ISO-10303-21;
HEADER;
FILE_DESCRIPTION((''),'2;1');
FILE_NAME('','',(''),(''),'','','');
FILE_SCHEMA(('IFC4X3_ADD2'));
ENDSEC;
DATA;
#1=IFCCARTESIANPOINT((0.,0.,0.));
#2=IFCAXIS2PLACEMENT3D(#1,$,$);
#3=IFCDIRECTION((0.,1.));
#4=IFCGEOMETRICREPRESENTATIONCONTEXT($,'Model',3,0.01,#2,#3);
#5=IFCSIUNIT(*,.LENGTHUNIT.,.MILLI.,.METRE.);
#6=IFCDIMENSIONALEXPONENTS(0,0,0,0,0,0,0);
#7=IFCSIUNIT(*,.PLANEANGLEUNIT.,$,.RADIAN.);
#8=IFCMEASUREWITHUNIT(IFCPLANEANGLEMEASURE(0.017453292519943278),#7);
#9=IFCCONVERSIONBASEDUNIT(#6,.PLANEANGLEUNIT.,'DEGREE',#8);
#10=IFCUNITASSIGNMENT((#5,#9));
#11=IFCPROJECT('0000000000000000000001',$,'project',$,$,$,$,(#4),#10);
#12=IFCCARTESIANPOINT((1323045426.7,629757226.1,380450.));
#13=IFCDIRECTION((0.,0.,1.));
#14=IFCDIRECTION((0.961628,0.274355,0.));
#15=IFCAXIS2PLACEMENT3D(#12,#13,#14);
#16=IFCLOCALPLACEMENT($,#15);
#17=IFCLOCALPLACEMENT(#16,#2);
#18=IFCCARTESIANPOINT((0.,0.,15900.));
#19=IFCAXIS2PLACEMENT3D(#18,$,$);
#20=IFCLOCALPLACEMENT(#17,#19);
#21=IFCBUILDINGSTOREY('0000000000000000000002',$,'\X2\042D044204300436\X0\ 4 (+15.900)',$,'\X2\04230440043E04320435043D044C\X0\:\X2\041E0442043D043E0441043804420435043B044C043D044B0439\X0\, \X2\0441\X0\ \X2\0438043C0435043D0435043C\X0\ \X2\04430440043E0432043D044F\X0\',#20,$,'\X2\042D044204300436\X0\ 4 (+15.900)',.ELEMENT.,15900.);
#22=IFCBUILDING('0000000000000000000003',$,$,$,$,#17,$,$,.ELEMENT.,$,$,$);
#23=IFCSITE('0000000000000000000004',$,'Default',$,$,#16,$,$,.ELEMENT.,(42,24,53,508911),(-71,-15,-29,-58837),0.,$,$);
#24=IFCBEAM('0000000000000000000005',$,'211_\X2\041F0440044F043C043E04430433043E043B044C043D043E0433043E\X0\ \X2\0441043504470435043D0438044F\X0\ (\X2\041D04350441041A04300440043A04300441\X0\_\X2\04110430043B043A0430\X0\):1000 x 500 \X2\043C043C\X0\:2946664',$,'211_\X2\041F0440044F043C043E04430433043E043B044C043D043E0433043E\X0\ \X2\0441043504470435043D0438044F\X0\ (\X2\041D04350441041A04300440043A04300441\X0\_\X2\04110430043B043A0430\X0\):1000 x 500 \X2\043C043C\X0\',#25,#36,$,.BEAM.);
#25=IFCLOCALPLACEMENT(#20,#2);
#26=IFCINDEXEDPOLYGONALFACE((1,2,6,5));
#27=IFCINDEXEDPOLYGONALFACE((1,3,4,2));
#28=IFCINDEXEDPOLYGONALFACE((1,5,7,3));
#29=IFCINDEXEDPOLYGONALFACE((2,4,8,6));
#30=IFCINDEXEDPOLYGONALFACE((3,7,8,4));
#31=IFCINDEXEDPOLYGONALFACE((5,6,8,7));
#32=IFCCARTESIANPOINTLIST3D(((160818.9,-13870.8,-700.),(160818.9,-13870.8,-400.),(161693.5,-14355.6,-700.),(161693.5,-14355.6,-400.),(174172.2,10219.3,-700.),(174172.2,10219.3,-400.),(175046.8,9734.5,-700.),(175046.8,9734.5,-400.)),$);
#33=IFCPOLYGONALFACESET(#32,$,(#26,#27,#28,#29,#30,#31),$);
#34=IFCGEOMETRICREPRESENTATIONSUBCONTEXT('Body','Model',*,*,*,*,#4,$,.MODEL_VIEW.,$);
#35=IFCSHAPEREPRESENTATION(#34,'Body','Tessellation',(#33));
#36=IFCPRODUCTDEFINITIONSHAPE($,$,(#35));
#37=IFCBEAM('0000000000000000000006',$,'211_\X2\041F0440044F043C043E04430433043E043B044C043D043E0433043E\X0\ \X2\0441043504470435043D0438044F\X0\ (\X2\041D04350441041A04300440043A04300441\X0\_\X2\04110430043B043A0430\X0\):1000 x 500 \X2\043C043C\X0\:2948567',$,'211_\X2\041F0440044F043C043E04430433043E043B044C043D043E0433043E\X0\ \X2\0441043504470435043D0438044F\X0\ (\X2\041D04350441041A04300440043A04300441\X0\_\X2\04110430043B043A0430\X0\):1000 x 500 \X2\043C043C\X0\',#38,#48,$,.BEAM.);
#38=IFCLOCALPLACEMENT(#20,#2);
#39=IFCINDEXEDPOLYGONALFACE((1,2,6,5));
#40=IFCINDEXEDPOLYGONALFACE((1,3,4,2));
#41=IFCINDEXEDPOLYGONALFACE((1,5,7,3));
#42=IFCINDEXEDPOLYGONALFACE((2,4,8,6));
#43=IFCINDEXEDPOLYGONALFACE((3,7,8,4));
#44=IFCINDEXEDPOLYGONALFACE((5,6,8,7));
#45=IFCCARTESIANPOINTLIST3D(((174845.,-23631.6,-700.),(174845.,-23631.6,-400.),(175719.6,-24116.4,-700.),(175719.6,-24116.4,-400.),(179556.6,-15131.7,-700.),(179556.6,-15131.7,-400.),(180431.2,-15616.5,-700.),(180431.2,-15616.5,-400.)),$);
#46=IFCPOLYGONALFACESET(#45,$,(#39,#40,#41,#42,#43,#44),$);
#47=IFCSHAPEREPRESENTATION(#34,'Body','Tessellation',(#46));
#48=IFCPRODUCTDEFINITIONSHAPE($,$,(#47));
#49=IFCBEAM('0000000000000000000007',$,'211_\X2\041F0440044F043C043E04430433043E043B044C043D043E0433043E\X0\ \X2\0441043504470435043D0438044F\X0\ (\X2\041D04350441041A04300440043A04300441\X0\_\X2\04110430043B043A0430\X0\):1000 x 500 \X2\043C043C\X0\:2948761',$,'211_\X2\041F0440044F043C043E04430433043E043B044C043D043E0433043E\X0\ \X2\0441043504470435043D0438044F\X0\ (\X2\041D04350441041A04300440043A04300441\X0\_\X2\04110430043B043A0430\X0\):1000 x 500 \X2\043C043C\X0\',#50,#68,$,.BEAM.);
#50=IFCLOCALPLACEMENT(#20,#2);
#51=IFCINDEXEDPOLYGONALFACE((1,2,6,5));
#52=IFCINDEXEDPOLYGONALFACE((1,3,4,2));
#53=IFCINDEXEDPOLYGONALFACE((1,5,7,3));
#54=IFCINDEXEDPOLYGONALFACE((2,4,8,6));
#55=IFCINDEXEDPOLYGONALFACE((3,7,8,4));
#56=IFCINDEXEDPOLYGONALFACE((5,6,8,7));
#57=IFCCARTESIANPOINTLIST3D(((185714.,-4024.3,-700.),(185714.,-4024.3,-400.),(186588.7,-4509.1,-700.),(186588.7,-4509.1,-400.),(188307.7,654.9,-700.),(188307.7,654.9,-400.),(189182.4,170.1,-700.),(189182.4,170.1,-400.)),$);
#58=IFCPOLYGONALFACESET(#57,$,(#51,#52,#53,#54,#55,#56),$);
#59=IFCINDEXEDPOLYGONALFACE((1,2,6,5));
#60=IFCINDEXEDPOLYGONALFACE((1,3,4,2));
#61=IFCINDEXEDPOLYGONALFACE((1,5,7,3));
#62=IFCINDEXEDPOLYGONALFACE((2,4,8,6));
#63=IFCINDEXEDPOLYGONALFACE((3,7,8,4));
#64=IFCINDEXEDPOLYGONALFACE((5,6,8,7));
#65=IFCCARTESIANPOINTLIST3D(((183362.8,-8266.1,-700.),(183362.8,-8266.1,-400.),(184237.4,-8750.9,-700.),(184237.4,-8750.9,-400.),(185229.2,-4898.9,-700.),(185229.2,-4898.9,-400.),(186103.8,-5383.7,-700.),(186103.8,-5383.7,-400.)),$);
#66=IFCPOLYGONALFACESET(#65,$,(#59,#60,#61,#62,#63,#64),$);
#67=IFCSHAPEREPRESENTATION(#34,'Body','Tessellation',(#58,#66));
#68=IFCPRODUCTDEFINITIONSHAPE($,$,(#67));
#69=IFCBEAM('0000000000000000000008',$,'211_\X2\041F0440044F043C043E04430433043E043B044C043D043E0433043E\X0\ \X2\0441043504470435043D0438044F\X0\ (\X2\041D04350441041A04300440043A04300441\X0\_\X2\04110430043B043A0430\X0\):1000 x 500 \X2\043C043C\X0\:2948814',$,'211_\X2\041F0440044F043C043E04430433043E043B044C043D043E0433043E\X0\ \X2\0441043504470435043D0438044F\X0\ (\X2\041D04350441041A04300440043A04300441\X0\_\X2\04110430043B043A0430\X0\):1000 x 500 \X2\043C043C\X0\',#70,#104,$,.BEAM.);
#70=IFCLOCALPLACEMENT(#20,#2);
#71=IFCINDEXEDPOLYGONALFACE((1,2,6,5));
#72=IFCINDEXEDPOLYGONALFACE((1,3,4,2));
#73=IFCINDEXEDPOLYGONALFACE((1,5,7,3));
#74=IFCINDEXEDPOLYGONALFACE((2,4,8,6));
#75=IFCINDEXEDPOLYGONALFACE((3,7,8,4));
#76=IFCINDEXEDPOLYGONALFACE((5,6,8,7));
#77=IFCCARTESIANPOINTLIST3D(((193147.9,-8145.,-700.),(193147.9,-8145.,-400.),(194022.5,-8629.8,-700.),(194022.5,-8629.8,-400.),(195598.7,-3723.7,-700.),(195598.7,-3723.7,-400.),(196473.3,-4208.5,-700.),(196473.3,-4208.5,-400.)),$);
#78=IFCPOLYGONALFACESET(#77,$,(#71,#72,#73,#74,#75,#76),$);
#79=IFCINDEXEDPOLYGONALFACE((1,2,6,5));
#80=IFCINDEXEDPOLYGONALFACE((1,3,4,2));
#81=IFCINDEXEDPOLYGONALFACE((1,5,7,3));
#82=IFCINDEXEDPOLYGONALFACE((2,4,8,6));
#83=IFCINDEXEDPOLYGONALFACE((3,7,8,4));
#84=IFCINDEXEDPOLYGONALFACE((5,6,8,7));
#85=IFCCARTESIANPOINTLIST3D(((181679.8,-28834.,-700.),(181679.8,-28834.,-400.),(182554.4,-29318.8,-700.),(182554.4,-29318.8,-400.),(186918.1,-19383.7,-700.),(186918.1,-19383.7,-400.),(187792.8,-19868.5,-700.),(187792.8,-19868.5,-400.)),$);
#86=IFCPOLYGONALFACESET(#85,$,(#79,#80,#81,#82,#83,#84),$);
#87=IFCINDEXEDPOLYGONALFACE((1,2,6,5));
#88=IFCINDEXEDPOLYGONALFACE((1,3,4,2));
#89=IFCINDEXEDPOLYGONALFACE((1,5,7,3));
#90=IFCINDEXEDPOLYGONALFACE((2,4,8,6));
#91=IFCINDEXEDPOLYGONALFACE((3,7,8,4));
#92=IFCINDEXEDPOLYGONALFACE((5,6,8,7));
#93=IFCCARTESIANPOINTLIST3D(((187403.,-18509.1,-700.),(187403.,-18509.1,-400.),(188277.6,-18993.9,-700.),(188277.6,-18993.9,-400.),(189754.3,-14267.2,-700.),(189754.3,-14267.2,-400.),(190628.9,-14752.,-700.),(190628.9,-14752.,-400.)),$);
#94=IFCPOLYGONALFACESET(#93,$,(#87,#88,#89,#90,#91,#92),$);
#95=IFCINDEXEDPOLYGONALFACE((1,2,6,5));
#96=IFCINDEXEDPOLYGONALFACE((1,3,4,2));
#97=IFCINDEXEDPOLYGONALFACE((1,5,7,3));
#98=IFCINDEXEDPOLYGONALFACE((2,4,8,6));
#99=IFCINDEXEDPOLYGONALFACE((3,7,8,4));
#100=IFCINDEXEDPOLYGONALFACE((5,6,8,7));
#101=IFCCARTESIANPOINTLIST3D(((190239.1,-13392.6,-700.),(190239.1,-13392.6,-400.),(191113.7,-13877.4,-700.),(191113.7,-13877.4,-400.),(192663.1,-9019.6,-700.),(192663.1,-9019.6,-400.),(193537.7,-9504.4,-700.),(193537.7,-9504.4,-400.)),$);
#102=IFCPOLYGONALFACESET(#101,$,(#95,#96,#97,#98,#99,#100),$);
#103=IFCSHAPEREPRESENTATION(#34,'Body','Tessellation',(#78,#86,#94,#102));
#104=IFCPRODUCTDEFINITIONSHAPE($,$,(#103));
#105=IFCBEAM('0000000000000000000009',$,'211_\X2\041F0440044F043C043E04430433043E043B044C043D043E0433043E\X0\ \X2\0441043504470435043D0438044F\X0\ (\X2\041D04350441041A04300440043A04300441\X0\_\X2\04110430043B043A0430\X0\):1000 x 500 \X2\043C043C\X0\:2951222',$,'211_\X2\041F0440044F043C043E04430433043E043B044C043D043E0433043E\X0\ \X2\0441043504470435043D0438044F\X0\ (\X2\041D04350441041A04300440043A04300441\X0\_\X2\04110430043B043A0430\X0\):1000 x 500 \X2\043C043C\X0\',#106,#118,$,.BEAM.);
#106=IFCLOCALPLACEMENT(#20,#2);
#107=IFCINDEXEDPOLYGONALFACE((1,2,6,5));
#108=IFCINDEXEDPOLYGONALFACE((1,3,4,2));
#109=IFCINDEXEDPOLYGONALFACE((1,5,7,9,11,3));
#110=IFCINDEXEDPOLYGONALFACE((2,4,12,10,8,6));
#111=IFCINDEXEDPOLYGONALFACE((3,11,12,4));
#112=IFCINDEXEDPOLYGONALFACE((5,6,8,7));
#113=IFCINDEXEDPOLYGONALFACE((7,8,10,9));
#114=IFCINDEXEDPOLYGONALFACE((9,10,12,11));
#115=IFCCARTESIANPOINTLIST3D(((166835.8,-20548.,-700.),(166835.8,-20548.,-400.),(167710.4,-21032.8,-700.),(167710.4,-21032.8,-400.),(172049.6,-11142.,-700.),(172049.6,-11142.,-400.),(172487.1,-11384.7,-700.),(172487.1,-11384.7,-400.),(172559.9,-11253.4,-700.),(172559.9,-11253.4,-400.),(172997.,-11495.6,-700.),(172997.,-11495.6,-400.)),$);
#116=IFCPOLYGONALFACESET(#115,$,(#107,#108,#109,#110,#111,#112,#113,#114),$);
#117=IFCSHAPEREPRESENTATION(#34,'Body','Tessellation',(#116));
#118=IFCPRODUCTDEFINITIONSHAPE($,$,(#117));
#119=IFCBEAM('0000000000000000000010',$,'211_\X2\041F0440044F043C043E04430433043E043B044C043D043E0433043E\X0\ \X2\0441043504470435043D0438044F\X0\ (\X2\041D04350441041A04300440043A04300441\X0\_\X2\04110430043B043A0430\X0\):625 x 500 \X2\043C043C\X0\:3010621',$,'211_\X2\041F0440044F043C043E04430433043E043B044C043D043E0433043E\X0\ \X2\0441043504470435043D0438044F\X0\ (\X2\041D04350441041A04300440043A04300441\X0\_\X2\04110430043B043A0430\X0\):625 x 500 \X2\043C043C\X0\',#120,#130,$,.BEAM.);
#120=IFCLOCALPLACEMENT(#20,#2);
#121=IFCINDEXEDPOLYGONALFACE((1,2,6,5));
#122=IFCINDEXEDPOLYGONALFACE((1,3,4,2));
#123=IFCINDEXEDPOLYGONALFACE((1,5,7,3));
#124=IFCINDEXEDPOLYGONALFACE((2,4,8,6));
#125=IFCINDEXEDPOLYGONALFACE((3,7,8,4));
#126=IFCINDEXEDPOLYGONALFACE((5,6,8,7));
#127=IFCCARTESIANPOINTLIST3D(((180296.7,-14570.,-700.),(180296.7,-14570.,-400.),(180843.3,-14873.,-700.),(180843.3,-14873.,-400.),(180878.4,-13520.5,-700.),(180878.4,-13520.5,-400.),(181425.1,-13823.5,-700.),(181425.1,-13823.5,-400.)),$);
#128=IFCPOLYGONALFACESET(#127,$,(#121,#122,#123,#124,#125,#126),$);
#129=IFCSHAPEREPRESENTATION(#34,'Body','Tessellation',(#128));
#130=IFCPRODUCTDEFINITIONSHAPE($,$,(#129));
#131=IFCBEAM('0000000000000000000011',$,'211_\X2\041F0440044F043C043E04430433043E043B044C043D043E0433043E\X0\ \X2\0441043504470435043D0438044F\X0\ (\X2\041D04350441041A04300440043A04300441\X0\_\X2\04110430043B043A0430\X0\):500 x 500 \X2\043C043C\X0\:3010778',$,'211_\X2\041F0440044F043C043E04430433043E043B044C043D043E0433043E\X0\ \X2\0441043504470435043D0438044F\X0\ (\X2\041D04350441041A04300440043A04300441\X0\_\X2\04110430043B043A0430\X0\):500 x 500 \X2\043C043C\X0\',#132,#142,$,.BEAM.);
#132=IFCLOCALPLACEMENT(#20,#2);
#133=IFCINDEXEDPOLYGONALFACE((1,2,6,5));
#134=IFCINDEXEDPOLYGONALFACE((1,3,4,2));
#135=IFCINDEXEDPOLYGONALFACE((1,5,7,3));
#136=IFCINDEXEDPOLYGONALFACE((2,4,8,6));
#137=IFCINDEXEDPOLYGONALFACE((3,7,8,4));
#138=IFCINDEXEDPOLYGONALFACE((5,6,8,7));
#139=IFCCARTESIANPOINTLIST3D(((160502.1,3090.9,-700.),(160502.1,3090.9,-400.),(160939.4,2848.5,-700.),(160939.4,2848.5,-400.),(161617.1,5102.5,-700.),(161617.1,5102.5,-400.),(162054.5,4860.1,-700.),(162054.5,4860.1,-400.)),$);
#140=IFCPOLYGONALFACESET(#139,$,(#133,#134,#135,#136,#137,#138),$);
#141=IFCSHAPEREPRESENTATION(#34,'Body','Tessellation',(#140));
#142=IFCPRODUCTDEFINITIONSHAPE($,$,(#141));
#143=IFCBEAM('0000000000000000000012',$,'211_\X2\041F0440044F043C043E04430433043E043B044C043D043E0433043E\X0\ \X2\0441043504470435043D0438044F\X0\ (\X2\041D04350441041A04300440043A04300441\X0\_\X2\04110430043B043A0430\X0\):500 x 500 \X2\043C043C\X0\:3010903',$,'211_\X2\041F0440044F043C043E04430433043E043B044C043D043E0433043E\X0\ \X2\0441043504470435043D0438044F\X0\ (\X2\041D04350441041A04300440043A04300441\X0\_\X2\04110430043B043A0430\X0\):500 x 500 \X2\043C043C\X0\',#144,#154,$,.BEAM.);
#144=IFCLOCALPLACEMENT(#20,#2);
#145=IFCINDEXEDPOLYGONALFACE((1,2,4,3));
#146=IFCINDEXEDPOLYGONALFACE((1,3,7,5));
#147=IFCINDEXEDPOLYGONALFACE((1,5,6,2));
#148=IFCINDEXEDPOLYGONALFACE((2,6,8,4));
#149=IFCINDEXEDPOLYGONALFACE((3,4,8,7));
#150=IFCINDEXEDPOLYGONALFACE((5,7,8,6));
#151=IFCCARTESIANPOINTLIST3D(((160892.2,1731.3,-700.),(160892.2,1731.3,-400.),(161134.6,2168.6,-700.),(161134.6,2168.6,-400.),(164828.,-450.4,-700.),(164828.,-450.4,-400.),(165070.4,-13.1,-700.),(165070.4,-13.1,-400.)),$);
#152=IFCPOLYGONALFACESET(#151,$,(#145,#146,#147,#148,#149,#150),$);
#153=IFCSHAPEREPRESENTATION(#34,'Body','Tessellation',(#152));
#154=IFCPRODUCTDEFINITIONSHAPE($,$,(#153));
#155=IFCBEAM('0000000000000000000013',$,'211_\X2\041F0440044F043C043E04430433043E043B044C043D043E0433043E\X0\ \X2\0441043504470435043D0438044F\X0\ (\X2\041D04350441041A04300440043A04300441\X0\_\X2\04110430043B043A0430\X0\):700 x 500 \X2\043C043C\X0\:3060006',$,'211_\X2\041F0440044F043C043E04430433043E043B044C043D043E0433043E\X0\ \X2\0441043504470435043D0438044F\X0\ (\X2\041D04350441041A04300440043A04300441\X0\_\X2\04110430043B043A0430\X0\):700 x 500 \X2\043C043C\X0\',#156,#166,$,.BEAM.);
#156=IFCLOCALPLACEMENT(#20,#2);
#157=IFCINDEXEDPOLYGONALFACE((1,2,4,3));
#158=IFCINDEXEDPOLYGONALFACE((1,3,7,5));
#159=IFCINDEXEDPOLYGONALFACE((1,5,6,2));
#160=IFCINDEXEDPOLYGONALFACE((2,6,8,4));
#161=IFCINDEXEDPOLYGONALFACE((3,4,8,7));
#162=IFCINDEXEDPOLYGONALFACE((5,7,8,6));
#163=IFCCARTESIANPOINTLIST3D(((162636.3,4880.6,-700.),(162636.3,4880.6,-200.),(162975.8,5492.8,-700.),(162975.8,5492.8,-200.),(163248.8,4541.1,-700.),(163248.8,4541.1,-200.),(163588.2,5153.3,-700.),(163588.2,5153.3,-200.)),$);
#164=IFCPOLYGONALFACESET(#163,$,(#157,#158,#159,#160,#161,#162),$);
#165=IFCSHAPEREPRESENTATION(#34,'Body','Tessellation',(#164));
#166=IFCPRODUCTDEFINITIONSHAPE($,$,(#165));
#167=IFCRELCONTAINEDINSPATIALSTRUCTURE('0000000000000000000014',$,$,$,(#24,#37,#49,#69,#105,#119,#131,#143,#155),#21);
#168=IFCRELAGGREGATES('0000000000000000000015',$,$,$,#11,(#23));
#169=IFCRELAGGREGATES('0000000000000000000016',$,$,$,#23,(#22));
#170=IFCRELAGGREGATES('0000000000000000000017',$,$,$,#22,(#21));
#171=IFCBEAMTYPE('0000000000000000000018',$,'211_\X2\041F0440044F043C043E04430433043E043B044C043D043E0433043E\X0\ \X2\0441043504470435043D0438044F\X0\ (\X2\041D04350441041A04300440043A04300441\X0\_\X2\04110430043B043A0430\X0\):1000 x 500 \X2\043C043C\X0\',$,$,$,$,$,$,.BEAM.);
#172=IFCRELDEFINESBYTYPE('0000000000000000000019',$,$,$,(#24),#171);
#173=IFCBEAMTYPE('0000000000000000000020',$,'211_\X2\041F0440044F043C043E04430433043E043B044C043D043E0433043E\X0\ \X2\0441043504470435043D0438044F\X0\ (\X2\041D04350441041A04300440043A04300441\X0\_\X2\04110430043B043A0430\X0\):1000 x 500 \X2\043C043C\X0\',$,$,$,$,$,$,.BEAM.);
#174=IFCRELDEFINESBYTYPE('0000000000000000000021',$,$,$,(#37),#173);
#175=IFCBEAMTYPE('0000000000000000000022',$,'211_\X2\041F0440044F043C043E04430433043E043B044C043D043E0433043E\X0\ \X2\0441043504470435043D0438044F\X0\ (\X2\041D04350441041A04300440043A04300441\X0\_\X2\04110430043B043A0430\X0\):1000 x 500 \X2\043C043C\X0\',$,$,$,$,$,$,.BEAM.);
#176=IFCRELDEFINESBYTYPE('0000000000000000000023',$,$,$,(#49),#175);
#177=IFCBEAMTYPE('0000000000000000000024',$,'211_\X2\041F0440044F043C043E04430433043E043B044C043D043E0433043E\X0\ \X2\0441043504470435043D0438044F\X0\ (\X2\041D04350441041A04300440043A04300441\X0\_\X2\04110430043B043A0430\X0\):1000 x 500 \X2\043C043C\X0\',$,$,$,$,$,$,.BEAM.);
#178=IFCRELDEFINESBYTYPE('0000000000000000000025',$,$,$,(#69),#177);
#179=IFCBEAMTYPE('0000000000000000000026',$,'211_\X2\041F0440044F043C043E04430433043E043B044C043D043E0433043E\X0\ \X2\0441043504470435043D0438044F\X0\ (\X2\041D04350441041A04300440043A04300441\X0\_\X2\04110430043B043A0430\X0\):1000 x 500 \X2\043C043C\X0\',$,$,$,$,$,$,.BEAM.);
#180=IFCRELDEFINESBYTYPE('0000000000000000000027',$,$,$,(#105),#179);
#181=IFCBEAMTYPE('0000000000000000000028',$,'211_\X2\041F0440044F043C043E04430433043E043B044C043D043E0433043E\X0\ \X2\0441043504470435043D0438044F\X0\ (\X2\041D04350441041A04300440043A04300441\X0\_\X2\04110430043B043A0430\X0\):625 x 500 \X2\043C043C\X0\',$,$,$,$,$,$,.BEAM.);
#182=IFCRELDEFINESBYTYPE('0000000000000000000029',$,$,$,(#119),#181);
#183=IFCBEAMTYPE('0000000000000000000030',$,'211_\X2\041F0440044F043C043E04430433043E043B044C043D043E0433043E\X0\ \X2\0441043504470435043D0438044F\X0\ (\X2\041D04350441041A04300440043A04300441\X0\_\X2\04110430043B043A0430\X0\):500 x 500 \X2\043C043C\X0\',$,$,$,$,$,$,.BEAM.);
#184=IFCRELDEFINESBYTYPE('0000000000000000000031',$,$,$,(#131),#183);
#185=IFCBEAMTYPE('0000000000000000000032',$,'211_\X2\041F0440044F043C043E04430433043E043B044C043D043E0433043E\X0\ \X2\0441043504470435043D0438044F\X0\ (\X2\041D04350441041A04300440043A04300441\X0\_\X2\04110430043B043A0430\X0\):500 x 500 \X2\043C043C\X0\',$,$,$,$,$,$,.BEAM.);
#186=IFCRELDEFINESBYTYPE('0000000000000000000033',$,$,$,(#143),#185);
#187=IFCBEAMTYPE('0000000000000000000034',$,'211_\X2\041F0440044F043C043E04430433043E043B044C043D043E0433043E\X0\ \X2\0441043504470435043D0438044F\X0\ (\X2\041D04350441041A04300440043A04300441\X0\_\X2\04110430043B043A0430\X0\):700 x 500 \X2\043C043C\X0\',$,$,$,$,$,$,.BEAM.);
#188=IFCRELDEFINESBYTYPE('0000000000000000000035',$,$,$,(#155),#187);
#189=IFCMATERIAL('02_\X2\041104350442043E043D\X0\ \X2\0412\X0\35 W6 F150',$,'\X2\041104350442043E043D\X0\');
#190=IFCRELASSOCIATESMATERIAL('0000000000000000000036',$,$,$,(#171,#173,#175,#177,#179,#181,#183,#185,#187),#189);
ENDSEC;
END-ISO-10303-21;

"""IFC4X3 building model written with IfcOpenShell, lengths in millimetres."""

from ifc_helpers import new_model, entity, si_unit, converted_unit, direction, frame, frame_2d, origin, place, context, subcontext, project, spatial, polyline, segment, composite_curve, rectangle, outline, extrude, clip, bounded_halfspace, source, transform, mapped, material, material_profile, profile_set, type_object, type_shapes, element, save


model = new_model("IFC4X3")

# Units and contexts
model_context = context("Model", 3, precision=0.01, world=origin(), true_north=direction((0.0, 1.0)))
body_context = subcontext(model_context, "Body", "Model", "MODEL_VIEW")
ifc_project = project(units=[si_unit("LENGTHUNIT", "METRE", prefix="MILLI"), converted_unit("PLANEANGLEUNIT", "DEGREE", entity("IfcPlaneAngleMeasure", 0.017453292519943278), si_unit("PLANEANGLEUNIT", "RADIAN"), dimensions=[0, 0, 0, 0, 0, 0, 0])], contexts=[model_context])

# Site, building, storey
site_placement = place(None, frame((1323045426.7, 629757226.1, 380450.0), z_axis=(0.0, 0.0, 1.0), x_axis=(0.961628, 0.274355, 0.0)))
site = spatial("IfcSite", under=ifc_project, at=site_placement, Name="Default", CompositionType="ELEMENT", RefLatitude=(42, 24, 53, 508911), RefLongitude=(-71, -15, -29, -58837), RefElevation=0.0)
building_placement = place(site_placement, origin())
building = spatial("IfcBuilding", under=site, at=building_placement, CompositionType="ELEMENT")
storey_placement = place(building_placement, frame((0.0, 0.0, 15900.0)))
storey = spatial("IfcBuildingStorey", under=building, at=storey_placement, Name="Этаж 4 (+15.900)", ObjectType="Уровень:Относительный, с именем уровня", LongName="Этаж 4 (+15.900)", CompositionType="ELEMENT", Elevation=15900.0)

# Beams
ifc_material = material(Name="02_Бетон В35 W6 F150", Category="Бетон")
ifc_material_profile_1 = material_profile(ifc_material, rectangle(XDim=300.0, YDim=1000.0, at=frame_2d((0.0, 0.0), x_axis=(1.0, 0.0))), Name="1000 x 500 мм")
ifc_profile_set_1 = profile_set([ifc_material_profile_1], Name="1000 x 500 мм")
beam_type_1 = type_object("IfcBeamType", Name="211_Прямоугольного сечения (НесКаркас_Балка):1000 x 500 мм", PredefinedType="BEAM", material=ifc_profile_set_1)
shared_shape_1 = source(origin(), body_context, "Body", "SweptSolid", [
    extrude(rectangle(XDim=300.0, YDim=1000.0, at=frame_2d((0.0, 0.0), x_axis=(1.0, 0.0))), frame((174609.5, 9976.9, 15350.0), z_axis=(-0.48481, -0.87462, 0.0), x_axis=(0.0, 0.0, -1.0)), (0.0, 0.0, 1.0), 27543.4),
])
type_shapes(beam_type_1, [shared_shape_1])
beam_1_placement = place(storey_placement, frame((0.0, 0.0, -15900.0)))
element("IfcBeam", 1, at=beam_1_placement, inside=storey, type_object=beam_type_1, Name="211_Прямоугольного сечения (НесКаркас_Балка):1000 x 500 мм:2946664", ObjectType="211_Прямоугольного сечения (НесКаркас_Балка):1000 x 500 мм", PredefinedType="BEAM", context=body_context, shape_type="MappedRepresentation", body=[
    mapped(shared_shape_1, transform((0.0, 0.0, 0.0), scale=1.0)),
])
beam_type_2 = type_object("IfcBeamType", Name="211_Прямоугольного сечения (НесКаркас_Балка):1000 x 500 мм", PredefinedType="BEAM", material=ifc_profile_set_1)
shared_shape_2 = source(origin(), body_context, "Body", "SweptSolid", [
    extrude(rectangle(XDim=300.0, YDim=1000.0, at=frame_2d((0.0, 0.0), x_axis=(1.0, 0.0))), frame((179993.9, -15374.1, 15350.0), z_axis=(-0.48481, -0.87462, 0.0), x_axis=(0.0, 0.0, -1.0)), (0.0, 0.0, 1.0), 9718.4),
])
type_shapes(beam_type_2, [shared_shape_2])
beam_2_placement = place(storey_placement, frame((0.0, 0.0, -15900.0)))
element("IfcBeam", 2, at=beam_2_placement, inside=storey, type_object=beam_type_2, Name="211_Прямоугольного сечения (НесКаркас_Балка):1000 x 500 мм:2948567", ObjectType="211_Прямоугольного сечения (НесКаркас_Балка):1000 x 500 мм", PredefinedType="BEAM", context=body_context, shape_type="MappedRepresentation", body=[
    mapped(shared_shape_2, transform((0.0, 0.0, 0.0), scale=1.0)),
])
beam_type_3 = type_object("IfcBeamType", Name="211_Прямоугольного сечения (НесКаркас_Балка):1000 x 500 мм", PredefinedType="BEAM", material=ifc_profile_set_1)
shared_shape_3 = source(origin(), body_context, "Body", "SweptSolid", [
    extrude(rectangle(XDim=300.0, YDim=1000.0, at=frame_2d((0.0, 0.0), x_axis=(1.0, 0.0))), frame((186151.3, -4266.7, 15350.0), z_axis=(0.48481, 0.87462, 0.0), x_axis=(0.0, 0.0, 1.0)), (0.0, 0.0, 1.0), 5350.0),
    extrude(rectangle(XDim=300.0, YDim=1000.0, at=frame_2d((0.0, 0.0), x_axis=(1.0, 0.0))), frame((183800.1, -8508.5, 15350.0), z_axis=(0.48481, 0.87462, 0.0), x_axis=(0.0, 0.0, 1.0)), (0.0, 0.0, 1.0), 3849.9),
])
type_shapes(beam_type_3, [shared_shape_3])
beam_3_placement = place(storey_placement, frame((0.0, 0.0, -15900.0)))
element("IfcBeam", 3, at=beam_3_placement, inside=storey, type_object=beam_type_3, Name="211_Прямоугольного сечения (НесКаркас_Балка):1000 x 500 мм:2948761", ObjectType="211_Прямоугольного сечения (НесКаркас_Балка):1000 x 500 мм", PredefinedType="BEAM", context=body_context, shape_type="MappedRepresentation", body=[
    mapped(shared_shape_3, transform((0.0, 0.0, 0.0), scale=1.0)),
])
beam_type_4 = type_object("IfcBeamType", Name="211_Прямоугольного сечения (НесКаркас_Балка):1000 x 500 мм", PredefinedType="BEAM", material=ifc_profile_set_1)
shared_shape_4 = source(origin(), body_context, "Body", "SweptSolid", [
    extrude(rectangle(XDim=300.0, YDim=1000.0, at=frame_2d((0.0, 0.0), x_axis=(1.0, 0.0))), frame((193585.2, -8387.4, 15350.0), z_axis=(0.48481, 0.87462, 0.0), x_axis=(0.0, 0.0, 1.0)), (0.0, 0.0, 1.0), 5055.1),
    extrude(rectangle(XDim=300.0, YDim=1000.0, at=frame_2d((0.0, 0.0), x_axis=(1.0, 0.0))), frame((182117.1, -29076.4, 15350.0), z_axis=(0.48481, 0.87462, 0.0), x_axis=(0.0, 0.0, 1.0)), (0.0, 0.0, 1.0), 10805.0),
    extrude(rectangle(XDim=300.0, YDim=1000.0, at=frame_2d((0.0, 0.0), x_axis=(1.0, 0.0))), frame((187840.3, -18751.5, 15350.0), z_axis=(0.48481, 0.87462, 0.0), x_axis=(0.0, 0.0, 1.0)), (0.0, 0.0, 1.0), 4850.0),
    extrude(rectangle(XDim=300.0, YDim=1000.0, at=frame_2d((0.0, 0.0), x_axis=(1.0, 0.0))), frame((190676.4, -13635.0, 15350.0), z_axis=(0.48481, 0.87462, 0.0), x_axis=(0.0, 0.0, 1.0)), (0.0, 0.0, 1.0), 4999.9),
])
type_shapes(beam_type_4, [shared_shape_4])
beam_4_placement = place(storey_placement, frame((0.0, 0.0, -15900.0)))
element("IfcBeam", 4, at=beam_4_placement, inside=storey, type_object=beam_type_4, Name="211_Прямоугольного сечения (НесКаркас_Балка):1000 x 500 мм:2948814", ObjectType="211_Прямоугольного сечения (НесКаркас_Балка):1000 x 500 мм", PredefinedType="BEAM", context=body_context, shape_type="MappedRepresentation", body=[
    mapped(shared_shape_4, transform((0.0, 0.0, 0.0), scale=1.0)),
])
beam_type_5 = type_object("IfcBeamType", Name="211_Прямоугольного сечения (НесКаркас_Балка):1000 x 500 мм", PredefinedType="BEAM", material=ifc_profile_set_1)
shared_shape_5 = source(origin(), body_context, "Body", "SweptSolid", [
    clip(clip(extrude(rectangle(XDim=300.0, YDim=1000.0, at=frame_2d((0.0, 0.0), x_axis=(1.0, 0.0))), frame((172559.6, -11253.2, 15350.0), z_axis=(-0.48481, -0.87462, 0.0), x_axis=(0.0, 0.0, -1.0)), (0.0, 0.0, 1.0), 10904.4), bounded_halfspace(frame((172729.6, -10947.4, 15450.0), z_axis=(-0.874547, 0.48494, 0.0), x_axis=(0.0, 0.0, 1.0)), False, frame((172559.6, -11253.2, 15350.0), z_axis=(-0.48481, -0.87462, 0.0), x_axis=(0.0, 0.0, -1.0)), polyline([(150.0, 0.3), (150.0, 0.3), (-150.0, 0.3), (-150.0, 0.3), (150.0, 0.3)]))), bounded_halfspace(frame((172487.1, -11384.7, 15700.0), z_axis=(0.48494, 0.874547, 0.0), x_axis=(-0.874547, 0.48494, 0.0)), False, frame((172559.6, -11253.2, 15350.0), z_axis=(-0.48481, -0.87462, 0.0), x_axis=(0.0, 0.0, -1.0)), polyline([(150.0, 0.3), (150.0, -500.0), (-150.0, -500.0), (-150.0, 0.3), (150.0, 0.3)]))),
])
type_shapes(beam_type_5, [shared_shape_5])
beam_5_placement = place(storey_placement, frame((0.0, 0.0, -15900.0)))
element("IfcBeam", 5, at=beam_5_placement, inside=storey, type_object=beam_type_5, Name="211_Прямоугольного сечения (НесКаркас_Балка):1000 x 500 мм:2951222", ObjectType="211_Прямоугольного сечения (НесКаркас_Балка):1000 x 500 мм", PredefinedType="BEAM", context=body_context, shape_type="MappedRepresentation", body=[
    mapped(shared_shape_5, transform((0.0, 0.0, 0.0), scale=1.0)),
])
ifc_material_profile_2 = material_profile(ifc_material, rectangle(XDim=300.0, YDim=625.0, at=frame_2d((0.0, 0.0), x_axis=(1.0, 0.0))), Name="625 x 500 мм")
ifc_profile_set_2 = profile_set([ifc_material_profile_2], Name="625 x 500 мм")
beam_type_6 = type_object("IfcBeamType", Name="211_Прямоугольного сечения (НесКаркас_Балка):625 x 500 мм", PredefinedType="BEAM", material=ifc_profile_set_2)
shared_shape_6 = source(origin(), body_context, "Body", "SweptSolid", [
    extrude(rectangle(XDim=300.0, YDim=625.0, at=frame_2d((0.0, 0.0), x_axis=(1.0, 0.0))), frame((180570.0, -14721.5, 15350.0), z_axis=(0.48481, 0.87462, 0.0), x_axis=(0.0, 0.0, 1.0)), (0.0, 0.0, 1.0), 1200.0),
])
type_shapes(beam_type_6, [shared_shape_6])
beam_6_placement = place(storey_placement, frame((0.0, 0.0, -15900.0)))
element("IfcBeam", 6, at=beam_6_placement, inside=storey, type_object=beam_type_6, Name="211_Прямоугольного сечения (НесКаркас_Балка):625 x 500 мм:3010621", ObjectType="211_Прямоугольного сечения (НесКаркас_Балка):625 x 500 мм", PredefinedType="BEAM", context=body_context, shape_type="MappedRepresentation", body=[
    mapped(shared_shape_6, transform((0.0, 0.0, 0.0), scale=1.0)),
])
ifc_material_profile_3 = material_profile(ifc_material, outline(composite_curve([segment(polyline([(-250.0, -250.0, 0.0), (-250.0, 50.0, 0.0)]), True, "CONTINUOUS"), segment(polyline([(-250.0, 50.0, 0.0), (250.0, 50.0, 0.0)]), True, "CONTINUOUS"), segment(polyline([(250.0, 50.0, 0.0), (250.0, -250.0, 0.0)]), True, "CONTINUOUS"), segment(polyline([(250.0, -250.0, 0.0), (-250.0, -250.0, 0.0)]), True, "CONTINUOUS")], self_intersect=False), kind="CURVE"), Name="500 x 500 мм")
ifc_profile_set_3 = profile_set([ifc_material_profile_3], Name="500 x 500 мм")
beam_type_7 = type_object("IfcBeamType", Name="211_Прямоугольного сечения (НесКаркас_Балка):500 x 500 мм", PredefinedType="BEAM", material=ifc_profile_set_3)
shared_shape_7 = source(origin(), body_context, "Body", "SweptSolid", [
    extrude(rectangle(XDim=300.0, YDim=500.0, at=frame_2d((0.0, 0.0), x_axis=(1.0, 0.0))), frame((160720.7, 2969.7, 15350.0), z_axis=(0.48481, 0.87462, 0.0), x_axis=(0.0, 0.0, 1.0)), (0.0, 0.0, 1.0), 2300.0),
])
type_shapes(beam_type_7, [shared_shape_7])
beam_7_placement = place(storey_placement, frame((0.0, 0.0, -15900.0)))
element("IfcBeam", 7, at=beam_7_placement, inside=storey, type_object=beam_type_7, Name="211_Прямоугольного сечения (НесКаркас_Балка):500 x 500 мм:3010778", ObjectType="211_Прямоугольного сечения (НесКаркас_Балка):500 x 500 мм", PredefinedType="BEAM", context=body_context, shape_type="MappedRepresentation", body=[
    mapped(shared_shape_7, transform((0.0, 0.0, 0.0), scale=1.0)),
])
beam_type_8 = type_object("IfcBeamType", Name="211_Прямоугольного сечения (НесКаркас_Балка):500 x 500 мм", PredefinedType="BEAM", material=ifc_profile_set_3)
shared_shape_8 = source(origin(), body_context, "Body", "SweptSolid", [
    extrude(rectangle(XDim=300.0, YDim=500.0, at=frame_2d((0.0, 0.0), x_axis=(1.0, 0.0))), frame((164949.2, -231.7, 15350.0), z_axis=(-0.87462, 0.48481, 0.0), x_axis=(0.0, 0.0, 1.0)), (0.0, 0.0, 1.0), 4500.0),
])
type_shapes(beam_type_8, [shared_shape_8])
beam_8_placement = place(storey_placement, frame((0.0, 0.0, -15900.0)))
element("IfcBeam", 8, at=beam_8_placement, inside=storey, type_object=beam_type_8, Name="211_Прямоугольного сечения (НесКаркас_Балка):500 x 500 мм:3010903", ObjectType="211_Прямоугольного сечения (НесКаркас_Балка):500 x 500 мм", PredefinedType="BEAM", context=body_context, shape_type="MappedRepresentation", body=[
    mapped(shared_shape_8, transform((0.0, 0.0, 0.0), scale=1.0)),
])
ifc_material_profile_4 = material_profile(ifc_material, rectangle(XDim=500.0, YDim=700.0, at=frame_2d((0.0, 0.0), x_axis=(1.0, 0.0))), Name="700 x 500 мм")
ifc_profile_set_4 = profile_set([ifc_material_profile_4], Name="700 x 500 мм")
beam_type_9 = type_object("IfcBeamType", Name="211_Прямоугольного сечения (НесКаркас_Балка):700 x 500 мм", PredefinedType="BEAM", material=ifc_profile_set_4)
shared_shape_9 = source(origin(), body_context, "Body", "SweptSolid", [
    extrude(rectangle(XDim=500.0, YDim=700.0, at=frame_2d((0.0, 0.0), x_axis=(1.0, 0.0))), frame((163418.5, 4847.2, 15450.0), z_axis=(-0.87458, 0.484881, 0.0), x_axis=(0.0, 0.0, 1.0)), (0.0, 0.0, 1.0), 700.3),
])
type_shapes(beam_type_9, [shared_shape_9])
beam_9_placement = place(storey_placement, frame((0.0, 0.0, -15900.0)))
element("IfcBeam", 9, at=beam_9_placement, inside=storey, type_object=beam_type_9, Name="211_Прямоугольного сечения (НесКаркас_Балка):700 x 500 мм:3060006", ObjectType="211_Прямоугольного сечения (НесКаркас_Балка):700 x 500 мм", PredefinedType="BEAM", context=body_context, shape_type="MappedRepresentation", body=[
    mapped(shared_shape_9, transform((0.0, 0.0, 0.0), scale=1.0)),
])

save(model, "model.ifc")
